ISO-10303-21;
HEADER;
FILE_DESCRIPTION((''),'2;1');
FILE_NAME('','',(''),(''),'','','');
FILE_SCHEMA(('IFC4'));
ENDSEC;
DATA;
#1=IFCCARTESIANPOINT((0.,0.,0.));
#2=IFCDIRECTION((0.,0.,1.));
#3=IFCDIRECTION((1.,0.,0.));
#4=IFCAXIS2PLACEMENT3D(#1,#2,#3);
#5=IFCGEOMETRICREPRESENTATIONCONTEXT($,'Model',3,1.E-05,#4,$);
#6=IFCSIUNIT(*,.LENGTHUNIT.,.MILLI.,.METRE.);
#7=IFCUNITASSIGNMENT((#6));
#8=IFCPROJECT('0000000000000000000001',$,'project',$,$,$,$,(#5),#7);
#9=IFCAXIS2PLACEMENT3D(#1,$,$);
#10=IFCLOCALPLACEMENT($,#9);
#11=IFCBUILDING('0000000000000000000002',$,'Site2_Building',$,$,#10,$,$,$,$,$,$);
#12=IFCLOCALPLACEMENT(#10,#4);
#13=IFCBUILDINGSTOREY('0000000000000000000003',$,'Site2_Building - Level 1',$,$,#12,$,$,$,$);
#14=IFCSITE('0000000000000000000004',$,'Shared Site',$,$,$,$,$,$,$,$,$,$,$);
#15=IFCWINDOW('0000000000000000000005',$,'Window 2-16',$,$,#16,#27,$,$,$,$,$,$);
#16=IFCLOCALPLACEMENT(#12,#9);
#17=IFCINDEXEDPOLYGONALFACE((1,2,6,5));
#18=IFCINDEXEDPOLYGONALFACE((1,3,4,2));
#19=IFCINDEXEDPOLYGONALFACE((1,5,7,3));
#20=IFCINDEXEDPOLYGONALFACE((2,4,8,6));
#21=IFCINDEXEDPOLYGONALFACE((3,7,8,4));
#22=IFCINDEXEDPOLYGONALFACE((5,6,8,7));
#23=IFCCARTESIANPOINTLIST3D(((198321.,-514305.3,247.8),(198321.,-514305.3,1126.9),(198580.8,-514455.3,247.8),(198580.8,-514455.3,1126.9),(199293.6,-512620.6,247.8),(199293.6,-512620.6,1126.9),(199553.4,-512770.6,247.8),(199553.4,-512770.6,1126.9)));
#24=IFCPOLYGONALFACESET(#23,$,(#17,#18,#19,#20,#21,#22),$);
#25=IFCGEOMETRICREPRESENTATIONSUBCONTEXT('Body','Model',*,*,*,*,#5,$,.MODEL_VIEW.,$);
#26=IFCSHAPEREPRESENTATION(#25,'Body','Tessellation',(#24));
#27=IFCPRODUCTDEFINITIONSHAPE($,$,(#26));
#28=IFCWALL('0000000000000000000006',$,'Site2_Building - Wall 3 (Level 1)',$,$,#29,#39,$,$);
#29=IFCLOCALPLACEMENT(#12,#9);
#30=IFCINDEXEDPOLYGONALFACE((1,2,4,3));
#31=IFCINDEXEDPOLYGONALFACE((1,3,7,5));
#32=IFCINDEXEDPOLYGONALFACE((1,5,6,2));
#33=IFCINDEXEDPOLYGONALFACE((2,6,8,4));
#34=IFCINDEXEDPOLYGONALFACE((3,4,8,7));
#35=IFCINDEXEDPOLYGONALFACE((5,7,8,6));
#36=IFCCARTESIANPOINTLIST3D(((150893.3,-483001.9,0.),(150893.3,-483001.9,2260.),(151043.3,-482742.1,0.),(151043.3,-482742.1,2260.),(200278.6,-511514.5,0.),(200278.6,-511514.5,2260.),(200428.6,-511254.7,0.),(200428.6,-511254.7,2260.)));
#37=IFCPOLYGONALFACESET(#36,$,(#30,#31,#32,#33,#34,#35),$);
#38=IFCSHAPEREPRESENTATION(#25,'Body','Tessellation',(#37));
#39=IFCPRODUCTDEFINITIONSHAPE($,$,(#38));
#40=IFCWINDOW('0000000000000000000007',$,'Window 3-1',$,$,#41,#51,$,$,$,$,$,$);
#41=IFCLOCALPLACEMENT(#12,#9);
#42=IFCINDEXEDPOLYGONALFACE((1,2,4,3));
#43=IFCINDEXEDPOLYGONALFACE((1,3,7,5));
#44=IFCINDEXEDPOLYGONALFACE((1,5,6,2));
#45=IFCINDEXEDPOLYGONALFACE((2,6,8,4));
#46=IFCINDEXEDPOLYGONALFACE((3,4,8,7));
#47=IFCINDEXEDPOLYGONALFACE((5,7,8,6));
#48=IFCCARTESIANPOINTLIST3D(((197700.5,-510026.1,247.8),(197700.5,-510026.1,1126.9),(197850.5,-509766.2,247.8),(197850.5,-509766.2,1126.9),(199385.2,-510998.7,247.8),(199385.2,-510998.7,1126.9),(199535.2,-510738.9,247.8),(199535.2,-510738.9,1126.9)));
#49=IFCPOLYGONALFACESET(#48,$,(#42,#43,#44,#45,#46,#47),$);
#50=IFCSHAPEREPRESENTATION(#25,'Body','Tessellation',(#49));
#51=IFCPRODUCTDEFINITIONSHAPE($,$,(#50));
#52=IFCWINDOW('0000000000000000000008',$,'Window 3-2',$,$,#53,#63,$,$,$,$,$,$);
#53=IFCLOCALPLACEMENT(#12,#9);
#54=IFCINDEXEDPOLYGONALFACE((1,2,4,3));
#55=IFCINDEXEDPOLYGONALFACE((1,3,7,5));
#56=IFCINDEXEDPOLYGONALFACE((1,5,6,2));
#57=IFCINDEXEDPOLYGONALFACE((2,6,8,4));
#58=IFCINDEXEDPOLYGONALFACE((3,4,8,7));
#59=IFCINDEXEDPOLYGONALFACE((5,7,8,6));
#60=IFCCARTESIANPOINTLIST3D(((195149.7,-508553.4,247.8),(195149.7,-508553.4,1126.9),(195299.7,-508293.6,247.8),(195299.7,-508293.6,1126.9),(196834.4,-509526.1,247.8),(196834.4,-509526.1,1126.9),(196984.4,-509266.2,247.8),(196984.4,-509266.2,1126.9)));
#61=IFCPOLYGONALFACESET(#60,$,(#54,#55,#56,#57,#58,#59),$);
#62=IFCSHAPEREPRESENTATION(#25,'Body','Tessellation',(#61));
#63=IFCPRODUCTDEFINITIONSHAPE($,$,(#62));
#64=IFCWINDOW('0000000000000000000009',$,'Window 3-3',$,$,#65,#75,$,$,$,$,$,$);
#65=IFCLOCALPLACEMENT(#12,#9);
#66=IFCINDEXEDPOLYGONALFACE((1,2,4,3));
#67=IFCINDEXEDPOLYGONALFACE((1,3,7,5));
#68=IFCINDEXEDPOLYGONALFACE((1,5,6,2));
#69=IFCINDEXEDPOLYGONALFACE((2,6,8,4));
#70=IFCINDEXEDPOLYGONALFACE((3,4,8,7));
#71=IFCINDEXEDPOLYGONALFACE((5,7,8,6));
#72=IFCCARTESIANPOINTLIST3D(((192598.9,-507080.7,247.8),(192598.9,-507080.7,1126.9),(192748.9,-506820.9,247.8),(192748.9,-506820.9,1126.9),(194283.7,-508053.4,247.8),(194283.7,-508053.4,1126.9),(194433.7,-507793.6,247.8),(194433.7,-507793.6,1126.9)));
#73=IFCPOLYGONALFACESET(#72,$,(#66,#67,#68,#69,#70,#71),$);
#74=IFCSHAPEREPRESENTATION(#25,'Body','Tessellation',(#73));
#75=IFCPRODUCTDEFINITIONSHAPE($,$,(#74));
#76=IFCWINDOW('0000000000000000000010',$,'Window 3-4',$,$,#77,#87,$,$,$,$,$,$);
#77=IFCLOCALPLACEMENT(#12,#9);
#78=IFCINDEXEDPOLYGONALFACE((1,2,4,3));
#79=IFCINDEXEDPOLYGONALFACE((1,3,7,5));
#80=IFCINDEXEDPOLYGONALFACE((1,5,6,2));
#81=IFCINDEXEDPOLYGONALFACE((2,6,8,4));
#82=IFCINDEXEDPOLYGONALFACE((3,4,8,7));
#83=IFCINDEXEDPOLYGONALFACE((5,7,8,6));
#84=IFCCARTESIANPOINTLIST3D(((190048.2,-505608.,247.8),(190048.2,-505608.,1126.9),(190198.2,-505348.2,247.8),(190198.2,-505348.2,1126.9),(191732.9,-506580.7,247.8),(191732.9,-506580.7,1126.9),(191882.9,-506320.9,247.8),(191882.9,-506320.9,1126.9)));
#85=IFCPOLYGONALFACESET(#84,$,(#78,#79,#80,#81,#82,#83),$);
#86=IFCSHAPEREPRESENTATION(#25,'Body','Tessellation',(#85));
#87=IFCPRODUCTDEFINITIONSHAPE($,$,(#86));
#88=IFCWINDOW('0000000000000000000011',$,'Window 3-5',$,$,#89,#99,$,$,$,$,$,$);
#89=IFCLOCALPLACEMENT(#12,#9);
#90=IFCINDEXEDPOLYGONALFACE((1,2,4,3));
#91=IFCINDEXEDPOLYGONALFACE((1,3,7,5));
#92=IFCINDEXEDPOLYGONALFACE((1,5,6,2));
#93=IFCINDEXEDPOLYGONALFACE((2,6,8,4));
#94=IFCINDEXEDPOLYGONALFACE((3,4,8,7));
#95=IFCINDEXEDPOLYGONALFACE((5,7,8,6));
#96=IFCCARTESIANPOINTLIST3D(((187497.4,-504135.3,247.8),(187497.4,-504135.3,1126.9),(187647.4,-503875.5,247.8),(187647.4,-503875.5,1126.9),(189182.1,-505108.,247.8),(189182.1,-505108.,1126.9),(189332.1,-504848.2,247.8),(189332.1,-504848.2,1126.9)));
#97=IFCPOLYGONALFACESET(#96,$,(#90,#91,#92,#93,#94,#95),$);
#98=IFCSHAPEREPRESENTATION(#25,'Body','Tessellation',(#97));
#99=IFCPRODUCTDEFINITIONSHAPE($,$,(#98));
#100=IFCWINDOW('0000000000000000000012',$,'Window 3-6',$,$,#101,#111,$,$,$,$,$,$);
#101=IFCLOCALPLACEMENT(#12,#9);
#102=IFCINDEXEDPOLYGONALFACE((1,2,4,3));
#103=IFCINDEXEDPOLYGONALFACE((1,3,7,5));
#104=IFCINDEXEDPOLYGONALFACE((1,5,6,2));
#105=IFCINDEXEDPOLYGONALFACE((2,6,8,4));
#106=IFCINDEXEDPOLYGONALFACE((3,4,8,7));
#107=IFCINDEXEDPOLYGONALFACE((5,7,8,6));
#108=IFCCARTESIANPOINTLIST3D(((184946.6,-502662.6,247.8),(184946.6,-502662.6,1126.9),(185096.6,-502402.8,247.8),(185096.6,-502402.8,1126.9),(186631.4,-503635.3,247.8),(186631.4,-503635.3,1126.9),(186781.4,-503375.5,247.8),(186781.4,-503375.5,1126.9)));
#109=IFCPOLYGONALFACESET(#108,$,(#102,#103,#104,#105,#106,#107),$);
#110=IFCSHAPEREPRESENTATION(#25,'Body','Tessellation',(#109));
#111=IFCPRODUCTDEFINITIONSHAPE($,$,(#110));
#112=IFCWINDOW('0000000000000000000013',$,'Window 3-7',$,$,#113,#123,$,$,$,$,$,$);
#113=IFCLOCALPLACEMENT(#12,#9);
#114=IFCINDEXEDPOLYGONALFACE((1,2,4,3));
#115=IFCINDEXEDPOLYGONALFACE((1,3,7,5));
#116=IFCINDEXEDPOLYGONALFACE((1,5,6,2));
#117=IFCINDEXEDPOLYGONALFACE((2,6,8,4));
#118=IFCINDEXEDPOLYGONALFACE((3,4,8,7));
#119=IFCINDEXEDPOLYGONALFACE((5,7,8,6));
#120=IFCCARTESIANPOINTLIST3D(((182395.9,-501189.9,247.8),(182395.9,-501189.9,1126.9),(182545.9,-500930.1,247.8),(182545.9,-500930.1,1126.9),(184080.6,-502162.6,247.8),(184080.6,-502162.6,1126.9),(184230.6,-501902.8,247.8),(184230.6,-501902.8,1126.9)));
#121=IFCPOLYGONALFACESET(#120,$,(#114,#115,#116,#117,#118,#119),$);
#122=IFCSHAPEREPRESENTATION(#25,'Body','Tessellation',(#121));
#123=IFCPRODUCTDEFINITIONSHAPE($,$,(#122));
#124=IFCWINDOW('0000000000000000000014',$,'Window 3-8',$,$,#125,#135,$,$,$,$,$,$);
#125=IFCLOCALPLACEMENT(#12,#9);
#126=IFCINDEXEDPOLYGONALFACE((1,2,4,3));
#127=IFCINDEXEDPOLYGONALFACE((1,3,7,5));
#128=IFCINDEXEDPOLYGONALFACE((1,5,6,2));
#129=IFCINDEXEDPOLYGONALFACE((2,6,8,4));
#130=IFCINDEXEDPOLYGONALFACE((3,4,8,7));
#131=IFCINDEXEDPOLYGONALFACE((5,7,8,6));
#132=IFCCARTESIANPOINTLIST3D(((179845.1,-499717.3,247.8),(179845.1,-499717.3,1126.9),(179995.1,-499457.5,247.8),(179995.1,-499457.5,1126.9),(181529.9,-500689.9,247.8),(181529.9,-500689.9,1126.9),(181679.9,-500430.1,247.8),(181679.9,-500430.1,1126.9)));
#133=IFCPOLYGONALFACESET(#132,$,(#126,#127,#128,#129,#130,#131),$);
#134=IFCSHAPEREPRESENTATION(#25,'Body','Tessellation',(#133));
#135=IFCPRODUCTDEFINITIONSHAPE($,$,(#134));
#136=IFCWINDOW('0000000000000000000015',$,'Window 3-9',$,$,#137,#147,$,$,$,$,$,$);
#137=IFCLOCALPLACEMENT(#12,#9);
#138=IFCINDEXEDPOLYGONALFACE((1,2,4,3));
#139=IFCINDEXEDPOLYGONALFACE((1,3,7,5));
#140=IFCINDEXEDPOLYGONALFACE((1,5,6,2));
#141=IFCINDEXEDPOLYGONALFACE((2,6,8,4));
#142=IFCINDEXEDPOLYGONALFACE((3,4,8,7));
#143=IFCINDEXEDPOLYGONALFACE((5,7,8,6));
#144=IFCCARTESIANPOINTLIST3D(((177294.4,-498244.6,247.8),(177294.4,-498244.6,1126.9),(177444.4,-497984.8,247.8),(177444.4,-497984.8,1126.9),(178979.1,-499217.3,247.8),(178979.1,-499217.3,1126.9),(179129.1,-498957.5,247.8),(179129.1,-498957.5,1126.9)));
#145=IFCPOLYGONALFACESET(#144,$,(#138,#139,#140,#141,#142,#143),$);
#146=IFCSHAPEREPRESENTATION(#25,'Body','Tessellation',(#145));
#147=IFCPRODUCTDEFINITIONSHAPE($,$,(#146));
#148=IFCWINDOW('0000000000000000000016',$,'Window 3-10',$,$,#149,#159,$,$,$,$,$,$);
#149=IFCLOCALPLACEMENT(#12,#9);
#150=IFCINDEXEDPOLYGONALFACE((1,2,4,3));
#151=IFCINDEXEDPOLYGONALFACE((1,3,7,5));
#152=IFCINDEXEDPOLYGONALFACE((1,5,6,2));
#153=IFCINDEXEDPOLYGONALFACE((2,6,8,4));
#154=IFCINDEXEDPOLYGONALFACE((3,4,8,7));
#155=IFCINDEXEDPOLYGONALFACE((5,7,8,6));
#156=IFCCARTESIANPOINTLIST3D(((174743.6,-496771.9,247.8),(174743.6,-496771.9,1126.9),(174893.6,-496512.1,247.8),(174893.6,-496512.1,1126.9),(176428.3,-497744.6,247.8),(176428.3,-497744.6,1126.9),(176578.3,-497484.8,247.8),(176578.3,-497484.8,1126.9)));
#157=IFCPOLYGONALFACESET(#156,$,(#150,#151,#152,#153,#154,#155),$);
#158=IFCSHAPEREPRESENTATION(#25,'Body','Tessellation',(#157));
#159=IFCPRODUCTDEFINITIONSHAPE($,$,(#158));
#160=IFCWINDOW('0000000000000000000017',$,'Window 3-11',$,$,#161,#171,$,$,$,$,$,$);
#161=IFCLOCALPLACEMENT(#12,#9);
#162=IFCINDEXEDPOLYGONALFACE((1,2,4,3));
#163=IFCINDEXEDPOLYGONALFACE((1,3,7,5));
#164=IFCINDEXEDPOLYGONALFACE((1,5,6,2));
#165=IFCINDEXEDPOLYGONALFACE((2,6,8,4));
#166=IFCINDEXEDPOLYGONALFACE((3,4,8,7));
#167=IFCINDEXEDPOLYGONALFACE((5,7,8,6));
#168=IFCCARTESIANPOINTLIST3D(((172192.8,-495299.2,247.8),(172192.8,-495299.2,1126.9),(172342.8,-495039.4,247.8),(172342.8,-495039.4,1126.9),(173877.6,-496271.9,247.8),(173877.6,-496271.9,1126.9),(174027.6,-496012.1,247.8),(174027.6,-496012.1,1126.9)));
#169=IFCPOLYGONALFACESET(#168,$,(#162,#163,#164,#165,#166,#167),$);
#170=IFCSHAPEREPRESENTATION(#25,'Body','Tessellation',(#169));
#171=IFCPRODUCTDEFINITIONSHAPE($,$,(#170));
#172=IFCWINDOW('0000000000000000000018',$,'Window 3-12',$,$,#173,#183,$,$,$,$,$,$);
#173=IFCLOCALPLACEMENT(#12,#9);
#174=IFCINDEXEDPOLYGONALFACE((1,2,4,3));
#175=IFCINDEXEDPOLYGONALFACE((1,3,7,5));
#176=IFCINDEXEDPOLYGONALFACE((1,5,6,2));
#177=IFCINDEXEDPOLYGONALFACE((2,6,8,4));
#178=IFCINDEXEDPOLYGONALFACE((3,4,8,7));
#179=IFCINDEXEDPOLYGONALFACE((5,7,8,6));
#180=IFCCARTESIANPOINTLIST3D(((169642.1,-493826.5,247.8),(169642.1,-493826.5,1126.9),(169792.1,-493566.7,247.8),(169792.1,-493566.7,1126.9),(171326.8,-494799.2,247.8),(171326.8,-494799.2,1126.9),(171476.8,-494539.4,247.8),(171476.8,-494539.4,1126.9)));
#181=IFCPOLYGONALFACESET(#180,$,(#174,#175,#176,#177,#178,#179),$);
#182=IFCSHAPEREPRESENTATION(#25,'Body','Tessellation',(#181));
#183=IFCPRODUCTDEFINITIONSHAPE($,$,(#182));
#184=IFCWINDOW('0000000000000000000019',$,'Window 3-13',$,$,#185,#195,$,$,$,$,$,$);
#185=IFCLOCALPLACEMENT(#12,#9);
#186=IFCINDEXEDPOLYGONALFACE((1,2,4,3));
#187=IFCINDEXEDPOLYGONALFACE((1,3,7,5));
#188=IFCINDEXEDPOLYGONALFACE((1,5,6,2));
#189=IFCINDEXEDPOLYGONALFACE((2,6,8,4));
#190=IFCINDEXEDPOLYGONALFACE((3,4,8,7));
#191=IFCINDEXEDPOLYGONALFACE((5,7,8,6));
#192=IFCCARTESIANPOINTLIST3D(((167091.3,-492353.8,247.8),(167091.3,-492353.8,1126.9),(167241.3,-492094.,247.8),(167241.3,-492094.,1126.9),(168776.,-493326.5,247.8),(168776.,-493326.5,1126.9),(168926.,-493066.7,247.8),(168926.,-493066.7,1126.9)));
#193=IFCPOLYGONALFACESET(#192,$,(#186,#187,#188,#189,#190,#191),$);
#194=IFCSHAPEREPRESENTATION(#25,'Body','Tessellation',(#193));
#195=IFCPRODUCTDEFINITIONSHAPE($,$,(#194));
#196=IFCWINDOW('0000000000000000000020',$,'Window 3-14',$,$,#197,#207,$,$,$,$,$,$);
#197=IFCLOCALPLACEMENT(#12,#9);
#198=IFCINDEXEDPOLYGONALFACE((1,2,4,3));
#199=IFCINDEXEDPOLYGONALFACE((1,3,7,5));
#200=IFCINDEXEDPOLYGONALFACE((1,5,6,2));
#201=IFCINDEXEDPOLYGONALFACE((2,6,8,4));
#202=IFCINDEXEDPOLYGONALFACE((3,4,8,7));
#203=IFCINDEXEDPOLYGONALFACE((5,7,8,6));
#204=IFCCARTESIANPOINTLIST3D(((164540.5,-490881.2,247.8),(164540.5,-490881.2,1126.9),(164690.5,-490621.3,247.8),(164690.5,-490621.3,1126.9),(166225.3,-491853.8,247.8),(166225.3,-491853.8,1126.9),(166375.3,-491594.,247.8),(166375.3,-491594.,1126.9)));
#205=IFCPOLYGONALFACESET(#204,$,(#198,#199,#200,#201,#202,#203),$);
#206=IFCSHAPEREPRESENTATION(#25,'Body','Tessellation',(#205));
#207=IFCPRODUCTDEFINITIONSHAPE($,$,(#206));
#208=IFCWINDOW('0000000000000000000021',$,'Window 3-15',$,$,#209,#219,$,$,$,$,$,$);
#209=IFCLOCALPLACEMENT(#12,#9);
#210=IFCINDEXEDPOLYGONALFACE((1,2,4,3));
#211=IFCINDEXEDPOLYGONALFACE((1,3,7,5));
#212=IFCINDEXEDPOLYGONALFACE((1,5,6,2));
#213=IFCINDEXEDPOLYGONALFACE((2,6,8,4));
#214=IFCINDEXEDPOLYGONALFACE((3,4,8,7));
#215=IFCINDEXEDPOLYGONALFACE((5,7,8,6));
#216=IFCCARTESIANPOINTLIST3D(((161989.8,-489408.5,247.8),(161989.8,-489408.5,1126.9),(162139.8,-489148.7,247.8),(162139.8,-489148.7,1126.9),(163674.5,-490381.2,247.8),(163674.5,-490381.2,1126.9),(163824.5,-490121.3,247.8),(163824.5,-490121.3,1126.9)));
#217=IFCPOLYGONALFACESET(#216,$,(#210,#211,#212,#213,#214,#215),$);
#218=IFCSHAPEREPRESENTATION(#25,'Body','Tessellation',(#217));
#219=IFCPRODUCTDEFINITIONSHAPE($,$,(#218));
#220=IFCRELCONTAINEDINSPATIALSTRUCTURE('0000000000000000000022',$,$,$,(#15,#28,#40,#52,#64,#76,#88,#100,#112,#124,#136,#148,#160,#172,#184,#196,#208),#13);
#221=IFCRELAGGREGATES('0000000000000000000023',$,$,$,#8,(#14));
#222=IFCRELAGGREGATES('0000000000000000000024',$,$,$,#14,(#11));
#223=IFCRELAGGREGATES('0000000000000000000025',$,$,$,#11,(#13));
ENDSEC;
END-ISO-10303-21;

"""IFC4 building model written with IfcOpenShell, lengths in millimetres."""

from ifc_helpers import new_model, si_unit, frame, origin, origin_with_axes, place, context, subcontext, project, spatial, indexed_curve, outline, extrude, element, save


model = new_model("IFC4")

# Units and contexts
model_context = context("Model", 3, precision=1e-05, world=origin_with_axes())
body_context = subcontext(model_context, "Body", "Model", "MODEL_VIEW")
ifc_project = project(units=[si_unit("LENGTHUNIT", "METRE", prefix="MILLI")], contexts=[model_context])

# Site, building, storey
site = spatial("IfcSite", under=ifc_project, Name="Shared Site")
building_placement = place(None, origin())
building = spatial("IfcBuilding", under=site, at=building_placement, Name="Site2_Building")
storey_placement = place(building_placement, origin_with_axes())
storey = spatial("IfcBuildingStorey", under=building, at=storey_placement, Name="Site2_Building - Level 1")

# Window
for number, where, z_axis, x_axis, name in (
    (1, (198580.8, -514455.3, 247.8), (0.0, 0.0, 1.0), (0.5, 0.866025, 0.0), "Window 2-16"),
):
    element("IfcWindow", number, at=place(storey_placement, frame(where, z_axis=z_axis, x_axis=x_axis)), inside=storey, Name=name, context=body_context, shape_type="SweptSolid", body=[
        extrude(outline(indexed_curve([(0.0, 0.0), (0.0, 300.0), (1945.4, 300.0), (1945.4, 0.0), (0.0, 0.0)], self_intersect=False)), origin_with_axes(), (0.0, 0.0, 1.0), 879.1),
    ])

# Wall
wall_1_placement = place(storey_placement, frame((200428.6, -511254.7, 0.0), z_axis=(0.0, 0.0, 1.0), x_axis=(-0.866025, 0.5, 0.0)))
element("IfcWall", 2, at=wall_1_placement, inside=storey, Name="Site2_Building - Wall 3 (Level 1)", context=body_context, shape_type="SweptSolid", body=[
    extrude(outline(indexed_curve([(0.0, 0.0), (0.0, 300.0), (57025.3, 300.0), (57025.3, 0.0), (0.0, 0.0)], self_intersect=False)), origin_with_axes(), (0.0, 0.0, 1.0), 2260.0),
])

# Windows
for number, where, z_axis, x_axis, name in (
    (3, (199535.2, -510738.9, 247.8), (0.0, 0.0, 1.0), (-0.866025, 0.5, 0.0), "Window 3-1"),
    (4, (196984.4, -509266.2, 247.8), (0.0, 0.0, 1.0), (-0.866025, 0.5, 0.0), "Window 3-2"),
    (5, (194433.7, -507793.6, 247.8), (0.0, 0.0, 1.0), (-0.866025, 0.5, 0.0), "Window 3-3"),
    (6, (191882.9, -506320.9, 247.8), (0.0, 0.0, 1.0), (-0.866025, 0.5, 0.0), "Window 3-4"),
    (7, (189332.1, -504848.2, 247.8), (0.0, 0.0, 1.0), (-0.866025, 0.5, 0.0), "Window 3-5"),
    (8, (186781.4, -503375.5, 247.8), (0.0, 0.0, 1.0), (-0.866025, 0.5, 0.0), "Window 3-6"),
    (9, (184230.6, -501902.8, 247.8), (0.0, 0.0, 1.0), (-0.866025, 0.5, 0.0), "Window 3-7"),
    (10, (181679.9, -500430.1, 247.8), (0.0, 0.0, 1.0), (-0.866025, 0.5, 0.0), "Window 3-8"),
    (11, (179129.1, -498957.5, 247.8), (0.0, 0.0, 1.0), (-0.866025, 0.5, 0.0), "Window 3-9"),
    (12, (176578.3, -497484.8, 247.8), (0.0, 0.0, 1.0), (-0.866025, 0.5, 0.0), "Window 3-10"),
    (13, (174027.6, -496012.1, 247.8), (0.0, 0.0, 1.0), (-0.866025, 0.5, 0.0), "Window 3-11"),
    (14, (171476.8, -494539.4, 247.8), (0.0, 0.0, 1.0), (-0.866025, 0.5, 0.0), "Window 3-12"),
    (15, (168926.0, -493066.7, 247.8), (0.0, 0.0, 1.0), (-0.866025, 0.5, 0.0), "Window 3-13"),
    (16, (166375.3, -491594.0, 247.8), (0.0, 0.0, 1.0), (-0.866025, 0.5, 0.0), "Window 3-14"),
    (17, (163824.5, -490121.3, 247.8), (0.0, 0.0, 1.0), (-0.866025, 0.5, 0.0), "Window 3-15"),
):
    element("IfcWindow", number, at=place(storey_placement, frame(where, z_axis=z_axis, x_axis=x_axis)), inside=storey, Name=name, context=body_context, shape_type="SweptSolid", body=[
        extrude(outline(indexed_curve([(0.0, 0.0), (0.0, 300.0), (1945.4, 300.0), (1945.4, 0.0), (0.0, 0.0)], self_intersect=False)), origin_with_axes(), (0.0, 0.0, 1.0), 879.1),
    ])

save(model, "model.ifc")
